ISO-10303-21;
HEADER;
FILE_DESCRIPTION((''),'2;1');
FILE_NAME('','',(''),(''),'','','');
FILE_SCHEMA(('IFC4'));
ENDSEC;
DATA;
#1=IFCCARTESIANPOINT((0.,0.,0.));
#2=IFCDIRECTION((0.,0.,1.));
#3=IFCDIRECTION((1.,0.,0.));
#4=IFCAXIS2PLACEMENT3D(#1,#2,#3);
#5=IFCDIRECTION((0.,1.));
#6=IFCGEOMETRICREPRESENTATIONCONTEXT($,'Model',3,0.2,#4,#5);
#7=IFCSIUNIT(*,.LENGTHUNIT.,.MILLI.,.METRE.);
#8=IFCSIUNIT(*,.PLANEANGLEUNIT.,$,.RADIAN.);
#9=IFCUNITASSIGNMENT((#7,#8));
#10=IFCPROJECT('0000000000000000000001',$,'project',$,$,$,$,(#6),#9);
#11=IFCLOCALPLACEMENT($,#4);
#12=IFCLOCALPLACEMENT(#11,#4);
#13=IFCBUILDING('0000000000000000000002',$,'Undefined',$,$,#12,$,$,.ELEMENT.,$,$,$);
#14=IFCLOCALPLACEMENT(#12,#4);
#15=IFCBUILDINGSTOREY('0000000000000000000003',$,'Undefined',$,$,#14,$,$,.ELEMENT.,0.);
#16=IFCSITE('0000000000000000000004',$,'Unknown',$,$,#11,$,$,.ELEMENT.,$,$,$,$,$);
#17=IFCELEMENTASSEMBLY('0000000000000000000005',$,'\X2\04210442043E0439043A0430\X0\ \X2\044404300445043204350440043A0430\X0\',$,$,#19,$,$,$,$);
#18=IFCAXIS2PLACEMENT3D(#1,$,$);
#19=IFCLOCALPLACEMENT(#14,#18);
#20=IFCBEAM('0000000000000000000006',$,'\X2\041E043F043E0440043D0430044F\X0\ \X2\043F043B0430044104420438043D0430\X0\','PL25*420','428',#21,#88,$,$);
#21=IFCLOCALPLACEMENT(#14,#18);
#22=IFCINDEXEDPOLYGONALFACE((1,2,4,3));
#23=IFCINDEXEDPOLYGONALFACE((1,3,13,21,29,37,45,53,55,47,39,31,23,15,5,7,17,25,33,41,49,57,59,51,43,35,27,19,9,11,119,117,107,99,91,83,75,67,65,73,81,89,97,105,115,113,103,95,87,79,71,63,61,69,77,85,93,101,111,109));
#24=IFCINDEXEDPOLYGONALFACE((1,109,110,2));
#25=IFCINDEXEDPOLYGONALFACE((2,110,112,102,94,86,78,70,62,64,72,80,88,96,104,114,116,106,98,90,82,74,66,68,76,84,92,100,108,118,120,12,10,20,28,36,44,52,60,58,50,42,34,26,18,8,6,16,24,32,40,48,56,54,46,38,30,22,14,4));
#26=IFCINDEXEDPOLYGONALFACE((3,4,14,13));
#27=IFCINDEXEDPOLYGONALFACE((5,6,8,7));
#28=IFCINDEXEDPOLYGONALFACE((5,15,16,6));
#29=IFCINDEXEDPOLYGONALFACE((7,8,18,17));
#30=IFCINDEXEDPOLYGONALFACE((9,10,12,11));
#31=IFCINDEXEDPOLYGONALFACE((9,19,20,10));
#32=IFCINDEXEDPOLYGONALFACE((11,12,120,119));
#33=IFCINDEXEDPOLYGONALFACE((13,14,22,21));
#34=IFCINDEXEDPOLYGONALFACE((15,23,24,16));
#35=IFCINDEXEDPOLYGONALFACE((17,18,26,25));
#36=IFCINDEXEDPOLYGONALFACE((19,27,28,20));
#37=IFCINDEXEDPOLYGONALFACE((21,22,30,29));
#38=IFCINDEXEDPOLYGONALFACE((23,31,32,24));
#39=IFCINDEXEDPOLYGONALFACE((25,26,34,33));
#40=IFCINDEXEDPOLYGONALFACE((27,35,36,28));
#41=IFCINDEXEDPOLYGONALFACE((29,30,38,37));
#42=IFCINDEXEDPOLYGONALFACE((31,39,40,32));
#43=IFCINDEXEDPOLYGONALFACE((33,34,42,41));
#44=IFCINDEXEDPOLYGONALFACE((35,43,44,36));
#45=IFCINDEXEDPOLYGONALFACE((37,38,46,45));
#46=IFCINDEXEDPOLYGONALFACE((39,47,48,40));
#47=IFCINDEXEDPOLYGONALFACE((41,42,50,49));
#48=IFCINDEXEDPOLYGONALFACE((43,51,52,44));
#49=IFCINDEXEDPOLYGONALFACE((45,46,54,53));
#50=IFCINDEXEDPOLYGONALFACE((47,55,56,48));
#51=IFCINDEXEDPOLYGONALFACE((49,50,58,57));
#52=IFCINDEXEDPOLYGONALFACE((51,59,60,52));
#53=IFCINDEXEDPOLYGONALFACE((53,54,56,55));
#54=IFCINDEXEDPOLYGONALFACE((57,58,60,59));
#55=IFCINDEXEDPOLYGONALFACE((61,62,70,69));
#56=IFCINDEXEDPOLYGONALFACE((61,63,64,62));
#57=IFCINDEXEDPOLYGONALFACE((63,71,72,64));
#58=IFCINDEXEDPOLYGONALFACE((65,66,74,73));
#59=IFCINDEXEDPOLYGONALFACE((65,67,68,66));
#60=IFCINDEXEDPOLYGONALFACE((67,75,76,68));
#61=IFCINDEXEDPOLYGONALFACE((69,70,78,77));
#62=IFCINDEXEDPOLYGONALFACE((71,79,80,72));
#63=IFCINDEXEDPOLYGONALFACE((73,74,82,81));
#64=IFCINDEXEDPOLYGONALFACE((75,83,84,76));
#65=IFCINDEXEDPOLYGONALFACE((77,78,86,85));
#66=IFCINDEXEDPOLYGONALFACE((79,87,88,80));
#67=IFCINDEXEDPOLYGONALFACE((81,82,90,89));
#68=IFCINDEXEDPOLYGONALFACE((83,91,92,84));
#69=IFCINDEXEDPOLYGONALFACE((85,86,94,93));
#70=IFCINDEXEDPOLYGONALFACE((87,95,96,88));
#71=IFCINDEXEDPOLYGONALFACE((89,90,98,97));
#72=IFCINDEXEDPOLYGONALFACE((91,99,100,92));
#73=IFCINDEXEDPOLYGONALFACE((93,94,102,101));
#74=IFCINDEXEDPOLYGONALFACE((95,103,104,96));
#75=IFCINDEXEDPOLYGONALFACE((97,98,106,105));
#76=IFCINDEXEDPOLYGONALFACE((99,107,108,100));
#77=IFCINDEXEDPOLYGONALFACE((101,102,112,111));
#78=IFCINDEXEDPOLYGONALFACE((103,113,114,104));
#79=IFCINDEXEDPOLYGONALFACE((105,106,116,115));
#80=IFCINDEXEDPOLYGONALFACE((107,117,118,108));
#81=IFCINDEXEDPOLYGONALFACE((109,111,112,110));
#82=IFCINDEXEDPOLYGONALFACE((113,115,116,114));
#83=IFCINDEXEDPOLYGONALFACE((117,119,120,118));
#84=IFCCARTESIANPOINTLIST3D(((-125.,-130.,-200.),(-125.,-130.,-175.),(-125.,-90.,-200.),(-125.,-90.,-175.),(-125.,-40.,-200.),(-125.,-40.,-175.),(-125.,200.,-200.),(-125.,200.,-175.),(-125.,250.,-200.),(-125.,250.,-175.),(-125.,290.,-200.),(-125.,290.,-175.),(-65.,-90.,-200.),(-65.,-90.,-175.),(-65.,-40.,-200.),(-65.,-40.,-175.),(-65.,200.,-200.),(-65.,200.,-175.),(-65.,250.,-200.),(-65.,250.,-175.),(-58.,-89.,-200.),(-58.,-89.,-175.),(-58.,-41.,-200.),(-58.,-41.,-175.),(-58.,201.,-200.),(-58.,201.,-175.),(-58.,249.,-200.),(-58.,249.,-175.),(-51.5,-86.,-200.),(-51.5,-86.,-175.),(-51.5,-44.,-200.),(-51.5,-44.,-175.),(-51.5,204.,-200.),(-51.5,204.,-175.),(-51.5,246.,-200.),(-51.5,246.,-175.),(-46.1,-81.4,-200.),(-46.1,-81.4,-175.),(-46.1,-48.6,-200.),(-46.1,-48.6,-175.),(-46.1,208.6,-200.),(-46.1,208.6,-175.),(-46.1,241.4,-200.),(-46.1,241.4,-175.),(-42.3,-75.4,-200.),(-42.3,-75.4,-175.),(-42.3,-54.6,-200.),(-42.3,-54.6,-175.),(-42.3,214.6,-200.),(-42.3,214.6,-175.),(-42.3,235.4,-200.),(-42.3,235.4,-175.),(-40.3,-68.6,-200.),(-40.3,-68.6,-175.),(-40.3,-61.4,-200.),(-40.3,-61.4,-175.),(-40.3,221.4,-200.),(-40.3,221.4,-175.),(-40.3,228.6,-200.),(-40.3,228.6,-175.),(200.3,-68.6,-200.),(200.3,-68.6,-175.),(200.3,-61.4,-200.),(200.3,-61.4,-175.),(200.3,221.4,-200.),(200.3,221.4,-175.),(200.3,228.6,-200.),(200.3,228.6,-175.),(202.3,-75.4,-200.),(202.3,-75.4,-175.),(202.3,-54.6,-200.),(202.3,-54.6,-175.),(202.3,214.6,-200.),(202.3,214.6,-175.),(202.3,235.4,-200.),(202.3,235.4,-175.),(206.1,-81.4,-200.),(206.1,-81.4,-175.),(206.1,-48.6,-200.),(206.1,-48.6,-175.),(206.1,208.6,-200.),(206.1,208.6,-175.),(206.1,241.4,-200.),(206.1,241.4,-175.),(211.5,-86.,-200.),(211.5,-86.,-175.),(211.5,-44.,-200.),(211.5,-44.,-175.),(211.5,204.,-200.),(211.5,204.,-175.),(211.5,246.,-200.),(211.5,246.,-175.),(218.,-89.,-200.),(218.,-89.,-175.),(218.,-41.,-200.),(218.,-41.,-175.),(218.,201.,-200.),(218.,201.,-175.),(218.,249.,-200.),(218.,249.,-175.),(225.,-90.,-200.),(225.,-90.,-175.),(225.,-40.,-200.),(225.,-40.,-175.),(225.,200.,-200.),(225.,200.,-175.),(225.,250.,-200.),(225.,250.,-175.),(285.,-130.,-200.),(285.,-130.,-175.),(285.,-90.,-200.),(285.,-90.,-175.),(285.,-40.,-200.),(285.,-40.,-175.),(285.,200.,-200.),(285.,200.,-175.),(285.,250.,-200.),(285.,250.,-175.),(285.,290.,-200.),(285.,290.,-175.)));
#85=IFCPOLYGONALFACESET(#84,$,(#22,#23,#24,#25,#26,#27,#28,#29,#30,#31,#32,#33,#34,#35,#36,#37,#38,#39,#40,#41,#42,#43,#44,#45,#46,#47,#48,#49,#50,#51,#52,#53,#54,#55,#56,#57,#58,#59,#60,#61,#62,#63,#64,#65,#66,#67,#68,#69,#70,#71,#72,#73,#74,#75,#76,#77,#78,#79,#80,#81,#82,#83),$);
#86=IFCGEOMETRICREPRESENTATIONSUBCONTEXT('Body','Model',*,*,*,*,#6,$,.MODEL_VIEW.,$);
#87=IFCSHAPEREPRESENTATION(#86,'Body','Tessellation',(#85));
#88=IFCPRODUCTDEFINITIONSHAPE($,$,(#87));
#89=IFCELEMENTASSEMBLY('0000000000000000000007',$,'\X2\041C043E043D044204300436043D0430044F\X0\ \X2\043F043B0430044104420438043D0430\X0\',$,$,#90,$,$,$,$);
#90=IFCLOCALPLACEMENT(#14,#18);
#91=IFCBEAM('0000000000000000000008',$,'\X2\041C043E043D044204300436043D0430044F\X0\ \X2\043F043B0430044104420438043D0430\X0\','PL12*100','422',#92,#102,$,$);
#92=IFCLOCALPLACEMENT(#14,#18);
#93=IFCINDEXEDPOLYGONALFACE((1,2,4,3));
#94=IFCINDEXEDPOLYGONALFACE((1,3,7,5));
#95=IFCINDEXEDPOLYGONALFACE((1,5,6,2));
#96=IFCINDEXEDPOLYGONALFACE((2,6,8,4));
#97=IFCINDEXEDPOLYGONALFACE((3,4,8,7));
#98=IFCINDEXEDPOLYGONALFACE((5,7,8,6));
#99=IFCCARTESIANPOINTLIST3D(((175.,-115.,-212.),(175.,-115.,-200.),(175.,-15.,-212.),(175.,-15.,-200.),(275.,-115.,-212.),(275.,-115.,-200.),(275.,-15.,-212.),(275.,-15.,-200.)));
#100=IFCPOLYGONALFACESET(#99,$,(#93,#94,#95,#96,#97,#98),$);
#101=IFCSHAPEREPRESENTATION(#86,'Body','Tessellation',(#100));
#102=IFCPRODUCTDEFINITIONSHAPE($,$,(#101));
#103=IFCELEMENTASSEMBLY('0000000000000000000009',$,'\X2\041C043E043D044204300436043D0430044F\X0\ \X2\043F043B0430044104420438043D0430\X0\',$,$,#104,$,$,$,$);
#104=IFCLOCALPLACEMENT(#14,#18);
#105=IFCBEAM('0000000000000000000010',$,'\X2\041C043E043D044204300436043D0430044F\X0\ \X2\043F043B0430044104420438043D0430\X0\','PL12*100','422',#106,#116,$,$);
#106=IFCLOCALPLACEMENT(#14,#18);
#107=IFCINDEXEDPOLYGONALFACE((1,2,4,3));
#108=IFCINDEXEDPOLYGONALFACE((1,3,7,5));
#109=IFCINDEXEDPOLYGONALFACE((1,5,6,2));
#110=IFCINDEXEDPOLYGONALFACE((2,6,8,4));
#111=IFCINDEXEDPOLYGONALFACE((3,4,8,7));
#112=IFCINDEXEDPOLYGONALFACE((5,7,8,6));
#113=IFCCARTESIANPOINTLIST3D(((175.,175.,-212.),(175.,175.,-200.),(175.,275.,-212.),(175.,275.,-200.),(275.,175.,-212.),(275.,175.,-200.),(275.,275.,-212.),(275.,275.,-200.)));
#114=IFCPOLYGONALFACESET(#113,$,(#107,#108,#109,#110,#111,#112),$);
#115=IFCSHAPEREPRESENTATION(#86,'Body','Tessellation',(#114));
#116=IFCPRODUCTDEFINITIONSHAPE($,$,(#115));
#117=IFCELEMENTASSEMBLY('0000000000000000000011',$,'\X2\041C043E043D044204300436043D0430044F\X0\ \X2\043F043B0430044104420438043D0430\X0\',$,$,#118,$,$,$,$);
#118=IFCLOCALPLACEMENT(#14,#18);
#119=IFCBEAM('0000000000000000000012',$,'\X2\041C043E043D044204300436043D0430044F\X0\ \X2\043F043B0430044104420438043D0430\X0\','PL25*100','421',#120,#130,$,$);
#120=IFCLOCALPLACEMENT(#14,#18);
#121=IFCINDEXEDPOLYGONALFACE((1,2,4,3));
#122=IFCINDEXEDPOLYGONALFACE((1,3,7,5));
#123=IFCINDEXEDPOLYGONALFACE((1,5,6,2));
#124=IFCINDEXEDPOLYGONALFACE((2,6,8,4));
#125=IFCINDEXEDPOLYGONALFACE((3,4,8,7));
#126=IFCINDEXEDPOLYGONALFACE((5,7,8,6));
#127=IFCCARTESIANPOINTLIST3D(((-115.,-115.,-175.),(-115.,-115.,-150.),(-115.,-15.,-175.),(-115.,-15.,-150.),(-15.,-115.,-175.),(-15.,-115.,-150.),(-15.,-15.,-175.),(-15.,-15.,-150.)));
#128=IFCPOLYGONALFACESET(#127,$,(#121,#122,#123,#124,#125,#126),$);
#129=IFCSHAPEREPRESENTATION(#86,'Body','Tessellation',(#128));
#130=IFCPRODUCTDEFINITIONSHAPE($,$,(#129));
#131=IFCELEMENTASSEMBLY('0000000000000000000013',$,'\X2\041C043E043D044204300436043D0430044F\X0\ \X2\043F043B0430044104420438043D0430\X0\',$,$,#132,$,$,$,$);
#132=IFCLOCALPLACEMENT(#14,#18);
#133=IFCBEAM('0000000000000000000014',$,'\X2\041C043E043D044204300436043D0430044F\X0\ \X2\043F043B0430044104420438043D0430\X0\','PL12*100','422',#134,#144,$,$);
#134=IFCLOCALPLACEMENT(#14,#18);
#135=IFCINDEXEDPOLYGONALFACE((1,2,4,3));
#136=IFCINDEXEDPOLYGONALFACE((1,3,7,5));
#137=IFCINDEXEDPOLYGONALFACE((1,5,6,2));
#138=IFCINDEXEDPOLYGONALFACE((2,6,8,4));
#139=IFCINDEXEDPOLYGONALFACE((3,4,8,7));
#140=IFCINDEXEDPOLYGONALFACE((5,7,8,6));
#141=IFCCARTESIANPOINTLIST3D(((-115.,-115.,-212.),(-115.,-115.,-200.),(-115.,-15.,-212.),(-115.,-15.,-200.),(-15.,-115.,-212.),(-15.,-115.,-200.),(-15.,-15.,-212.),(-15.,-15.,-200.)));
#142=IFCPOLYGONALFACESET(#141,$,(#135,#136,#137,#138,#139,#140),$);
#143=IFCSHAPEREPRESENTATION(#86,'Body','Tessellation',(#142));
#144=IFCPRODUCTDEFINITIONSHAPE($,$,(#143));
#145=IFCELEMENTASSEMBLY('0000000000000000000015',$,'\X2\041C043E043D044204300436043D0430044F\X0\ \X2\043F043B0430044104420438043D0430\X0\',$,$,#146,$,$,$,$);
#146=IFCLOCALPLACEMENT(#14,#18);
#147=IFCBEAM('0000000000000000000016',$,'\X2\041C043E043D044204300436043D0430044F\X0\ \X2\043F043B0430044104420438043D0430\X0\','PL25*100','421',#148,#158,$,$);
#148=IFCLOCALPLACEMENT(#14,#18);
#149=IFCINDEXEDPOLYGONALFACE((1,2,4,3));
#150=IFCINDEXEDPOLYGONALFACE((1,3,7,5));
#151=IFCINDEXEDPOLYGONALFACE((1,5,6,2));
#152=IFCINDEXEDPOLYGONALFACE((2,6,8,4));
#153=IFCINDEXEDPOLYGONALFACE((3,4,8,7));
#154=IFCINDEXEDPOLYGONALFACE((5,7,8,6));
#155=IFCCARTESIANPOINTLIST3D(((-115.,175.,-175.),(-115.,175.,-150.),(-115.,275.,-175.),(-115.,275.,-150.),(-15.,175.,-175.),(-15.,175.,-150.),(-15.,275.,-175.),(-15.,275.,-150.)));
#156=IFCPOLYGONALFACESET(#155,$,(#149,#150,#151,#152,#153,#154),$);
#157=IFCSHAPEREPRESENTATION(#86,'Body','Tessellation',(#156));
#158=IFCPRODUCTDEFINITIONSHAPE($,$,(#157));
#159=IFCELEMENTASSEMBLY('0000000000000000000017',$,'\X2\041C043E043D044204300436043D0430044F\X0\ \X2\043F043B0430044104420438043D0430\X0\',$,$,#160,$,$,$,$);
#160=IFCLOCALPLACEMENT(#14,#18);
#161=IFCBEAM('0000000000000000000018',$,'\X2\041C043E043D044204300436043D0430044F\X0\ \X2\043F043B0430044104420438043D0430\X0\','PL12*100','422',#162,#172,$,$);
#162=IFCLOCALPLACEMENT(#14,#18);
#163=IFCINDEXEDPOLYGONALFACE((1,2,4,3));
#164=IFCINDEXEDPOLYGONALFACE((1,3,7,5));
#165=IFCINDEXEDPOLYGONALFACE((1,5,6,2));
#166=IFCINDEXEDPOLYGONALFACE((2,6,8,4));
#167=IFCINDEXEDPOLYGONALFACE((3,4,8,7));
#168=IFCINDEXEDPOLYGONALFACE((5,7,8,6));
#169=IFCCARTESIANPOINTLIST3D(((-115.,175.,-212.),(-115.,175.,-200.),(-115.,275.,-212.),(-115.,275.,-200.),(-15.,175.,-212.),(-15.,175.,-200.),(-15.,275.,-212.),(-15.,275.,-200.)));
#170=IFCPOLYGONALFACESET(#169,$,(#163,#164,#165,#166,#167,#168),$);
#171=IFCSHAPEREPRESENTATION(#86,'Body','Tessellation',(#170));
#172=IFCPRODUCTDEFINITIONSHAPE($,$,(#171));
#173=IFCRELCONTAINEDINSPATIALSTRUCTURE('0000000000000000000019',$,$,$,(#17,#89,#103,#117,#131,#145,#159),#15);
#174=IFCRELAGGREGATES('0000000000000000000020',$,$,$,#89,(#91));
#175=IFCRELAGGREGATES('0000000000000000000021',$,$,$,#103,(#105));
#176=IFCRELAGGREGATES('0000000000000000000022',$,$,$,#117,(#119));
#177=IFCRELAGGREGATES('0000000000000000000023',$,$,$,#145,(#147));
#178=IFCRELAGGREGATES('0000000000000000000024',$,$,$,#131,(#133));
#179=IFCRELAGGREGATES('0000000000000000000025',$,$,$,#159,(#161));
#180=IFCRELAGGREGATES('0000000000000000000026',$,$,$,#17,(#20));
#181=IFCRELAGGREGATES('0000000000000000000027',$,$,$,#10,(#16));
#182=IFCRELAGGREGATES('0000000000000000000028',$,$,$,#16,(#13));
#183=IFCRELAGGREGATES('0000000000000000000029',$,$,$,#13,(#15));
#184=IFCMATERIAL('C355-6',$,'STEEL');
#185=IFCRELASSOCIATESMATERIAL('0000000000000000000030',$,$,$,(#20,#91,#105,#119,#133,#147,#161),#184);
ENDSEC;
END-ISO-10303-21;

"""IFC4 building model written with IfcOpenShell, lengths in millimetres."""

from ifc_helpers import new_model, si_unit, direction, frame, origin_with_axes, place, context, subcontext, project, spatial, line, arc, indexed_curve, outline, extrude, material, element, aggregate, save


model = new_model("IFC4")

# Units and contexts
model_context = context("Model", 3, precision=0.2, world=origin_with_axes(), true_north=direction((0.0, 1.0)))
body_context = subcontext(model_context, "Body", "Model", "MODEL_VIEW")
ifc_project = project(units=[si_unit("LENGTHUNIT", "METRE", prefix="MILLI"), si_unit("PLANEANGLEUNIT", "RADIAN")], contexts=[model_context])

# Site, building, storey
site_placement = place(None, origin_with_axes())
site = spatial("IfcSite", under=ifc_project, at=site_placement, Name="Unknown", CompositionType="ELEMENT")
building_placement = place(site_placement, origin_with_axes())
building = spatial("IfcBuilding", under=site, at=building_placement, Name="Undefined", CompositionType="ELEMENT")
storey_placement = place(building_placement, origin_with_axes())
storey = spatial("IfcBuildingStorey", under=building, at=storey_placement, Name="Undefined", CompositionType="ELEMENT", Elevation=0.0)

# Element assembly, beam, voiding features
assembly_1_placement = place(storey_placement, frame((80.0, 80.0, -200.0), z_axis=(0.0, -1.0, 0.0), x_axis=(0.0, 0.0, 1.0)))
assembly_1 = element("IfcElementAssembly", 1, at=assembly_1_placement, inside=storey, Name="Стойка фахверка")
ifc_material_1 = material(Name="C355-6", Category="STEEL")
beam_1_placement = place(assembly_1_placement, frame((12.5, 205.0, 0.0), z_axis=(-1.0, 0.0, 0.0), x_axis=(0.0, -1.0, 0.0)))
beam_1 = element("IfcBeam", 2, at=beam_1_placement, material=ifc_material_1, Name="Опорная пластина", Description="PL25*420", ObjectType="428", context=body_context, shape_type="SolidModel", body=[
    extrude(outline(indexed_curve([(-12.5, -210.0), (12.5, -210.0), (12.5, 210.0), (-12.5, 210.0)], segments=[line(1, 2, 3, 4, 1)])), frame((0.0, 0.0, 0.0), z_axis=(-1.0, 0.0, 0.0), x_axis=(0.0, 0.0, 1.0)), (0.0, 0.0, -1.0), 410.0),
])
voiding_feature_1_placement = place(beam_1_placement, frame((410.0, 170.0, 0.0), z_axis=(0.0, 0.0, -1.0), x_axis=(0.0, -1.0, 0.0)))
element("IfcVoidingFeature", 3, at=voiding_feature_1_placement, cuts=beam_1, Name="Пластина", ObjectType="(?)", PredefinedType="HOLE", context=body_context, shape_type="SolidModel", body=[
    extrude(outline(indexed_curve([(0.0, 0.0), (50.0, 0.0), (50.0, 60.0), (42.7, 77.7), (25.0, 85.0), (25.0, 85.0), (7.3, 77.7), (0.0, 60.0)], segments=[line(1, 2, 3), arc(3, 4, 5), line(5, 6), arc(6, 7, 8), line(8, 1)])), frame((0.0, 0.0, 12.5), z_axis=(0.0, 0.0, 1.0), x_axis=(1.0, 0.0, 0.0)), (0.0, 0.0, -1.0), 25.0),
])
voiding_feature_2_placement = place(beam_1_placement, frame((410.0, -120.0, 0.0), z_axis=(0.0, 0.0, -1.0), x_axis=(0.0, -1.0, 0.0)))
element("IfcVoidingFeature", 4, at=voiding_feature_2_placement, cuts=beam_1, Name="Пластина", ObjectType="(?)", PredefinedType="HOLE", context=body_context, shape_type="SolidModel", body=[
    extrude(outline(indexed_curve([(0.0, 0.0), (50.0, 0.0), (50.0, 60.0), (42.7, 77.7), (25.0, 85.0), (25.0, 85.0), (7.3, 77.7), (0.0, 60.0)], segments=[line(1, 2, 3), arc(3, 4, 5), line(5, 6), arc(6, 7, 8), line(8, 1)])), frame((0.0, 0.0, 12.5), z_axis=(0.0, 0.0, 1.0), x_axis=(1.0, 0.0, 0.0)), (0.0, 0.0, -1.0), 25.0),
])
voiding_feature_3_placement = place(beam_1_placement, frame((0.0, 120.0, 0.0), z_axis=(0.0, 0.0, -1.0), x_axis=(0.0, 1.0, 0.0)))
element("IfcVoidingFeature", 5, at=voiding_feature_3_placement, cuts=beam_1, Name="Пластина", ObjectType="(?)", PredefinedType="HOLE", context=body_context, shape_type="SolidModel", body=[
    extrude(outline(indexed_curve([(0.0, 0.0), (50.0, 0.0), (50.0, 60.0), (42.7, 77.7), (25.0, 85.0), (25.0, 85.0), (7.3, 77.7), (0.0, 60.0)], segments=[line(1, 2, 3), arc(3, 4, 5), line(5, 6), arc(6, 7, 8), line(8, 1)])), frame((0.0, 0.0, 12.5), z_axis=(0.0, 0.0, 1.0), x_axis=(1.0, 0.0, 0.0)), (0.0, 0.0, -1.0), 25.0),
])
voiding_feature_4_placement = place(beam_1_placement, frame((0.0, -170.0, 0.0), z_axis=(0.0, 0.0, -1.0), x_axis=(0.0, 1.0, 0.0)))
element("IfcVoidingFeature", 6, at=voiding_feature_4_placement, cuts=beam_1, Name="Пластина", ObjectType="(?)", PredefinedType="HOLE", context=body_context, shape_type="SolidModel", body=[
    extrude(outline(indexed_curve([(0.0, 0.0), (50.0, 0.0), (50.0, 60.0), (42.7, 77.7), (25.0, 85.0), (25.0, 85.0), (7.3, 77.7), (0.0, 60.0)], segments=[line(1, 2, 3), arc(3, 4, 5), line(5, 6), arc(6, 7, 8), line(8, 1)])), frame((0.0, 0.0, 12.5), z_axis=(0.0, 0.0, 1.0), x_axis=(1.0, 0.0, 0.0)), (0.0, 0.0, -1.0), 25.0),
])

# Element assemblies, beams
assembly_2_placement = place(storey_placement, frame((175.0, -65.0, -206.0), z_axis=(0.0, 0.0, -1.0), x_axis=(1.0, 0.0, 0.0)))
assembly_2 = element("IfcElementAssembly", 7, at=assembly_2_placement, inside=storey, Name="Монтажная пластина")
beam_2_placement = place(assembly_2_placement, origin_with_axes())
beam_2 = element("IfcBeam", 8, at=beam_2_placement, material=ifc_material_1, Name="Монтажная пластина", Description="PL12*100", ObjectType="422", context=body_context, shape_type="SolidModel", body=[
    extrude(outline(indexed_curve([(-6.0, -50.0), (6.0, -50.0), (6.0, 50.0), (-6.0, 50.0)], segments=[line(1, 2, 3, 4, 1)])), frame((0.0, 0.0, 0.0), z_axis=(-1.0, 0.0, 0.0), x_axis=(0.0, 0.0, 1.0)), (0.0, 0.0, -1.0), 100.0),
])
aggregate(assembly_2, [beam_2])
assembly_3_placement = place(storey_placement, frame((175.0, 225.0, -206.0), z_axis=(0.0, 0.0, -1.0), x_axis=(1.0, 0.0, 0.0)))
assembly_3 = element("IfcElementAssembly", 9, at=assembly_3_placement, inside=storey, Name="Монтажная пластина")
beam_3_placement = place(assembly_3_placement, origin_with_axes())
beam_3 = element("IfcBeam", 10, at=beam_3_placement, material=ifc_material_1, Name="Монтажная пластина", Description="PL12*100", ObjectType="422", context=body_context, shape_type="SolidModel", body=[
    extrude(outline(indexed_curve([(-6.0, -50.0), (6.0, -50.0), (6.0, 50.0), (-6.0, 50.0)], segments=[line(1, 2, 3, 4, 1)])), frame((0.0, 0.0, 0.0), z_axis=(-1.0, 0.0, 0.0), x_axis=(0.0, 0.0, 1.0)), (0.0, 0.0, -1.0), 100.0),
])
aggregate(assembly_3, [beam_3])
assembly_4_placement = place(storey_placement, frame((-115.0, -65.0, -162.5), z_axis=(0.0, 0.0, -1.0), x_axis=(1.0, 0.0, 0.0)))
assembly_4 = element("IfcElementAssembly", 11, at=assembly_4_placement, inside=storey, Name="Монтажная пластина")
beam_4_placement = place(assembly_4_placement, origin_with_axes())
beam_4 = element("IfcBeam", 12, at=beam_4_placement, material=ifc_material_1, Name="Монтажная пластина", Description="PL25*100", ObjectType="421", context=body_context, shape_type="SolidModel", body=[
    extrude(outline(indexed_curve([(-12.5, -50.0), (12.5, -50.0), (12.5, 50.0), (-12.5, 50.0)], segments=[line(1, 2, 3, 4, 1)])), frame((0.0, 0.0, 0.0), z_axis=(-1.0, 0.0, 0.0), x_axis=(0.0, 0.0, 1.0)), (0.0, 0.0, -1.0), 100.0),
])
assembly_5_placement = place(storey_placement, frame((-115.0, -65.0, -206.0), z_axis=(0.0, 0.0, -1.0), x_axis=(1.0, 0.0, 0.0)))
assembly_5 = element("IfcElementAssembly", 13, at=assembly_5_placement, inside=storey, Name="Монтажная пластина")
beam_5_placement = place(assembly_5_placement, origin_with_axes())
beam_5 = element("IfcBeam", 14, at=beam_5_placement, material=ifc_material_1, Name="Монтажная пластина", Description="PL12*100", ObjectType="422", context=body_context, shape_type="SolidModel", body=[
    extrude(outline(indexed_curve([(-6.0, -50.0), (6.0, -50.0), (6.0, 50.0), (-6.0, 50.0)], segments=[line(1, 2, 3, 4, 1)])), frame((0.0, 0.0, 0.0), z_axis=(-1.0, 0.0, 0.0), x_axis=(0.0, 0.0, 1.0)), (0.0, 0.0, -1.0), 100.0),
])
assembly_6_placement = place(storey_placement, frame((-115.0, 225.0, -162.5), z_axis=(0.0, 0.0, -1.0), x_axis=(1.0, 0.0, 0.0)))
assembly_6 = element("IfcElementAssembly", 15, at=assembly_6_placement, inside=storey, Name="Монтажная пластина")
beam_6_placement = place(assembly_6_placement, origin_with_axes())
beam_6 = element("IfcBeam", 16, at=beam_6_placement, material=ifc_material_1, Name="Монтажная пластина", Description="PL25*100", ObjectType="421", context=body_context, shape_type="SolidModel", body=[
    extrude(outline(indexed_curve([(-12.5, -50.0), (12.5, -50.0), (12.5, 50.0), (-12.5, 50.0)], segments=[line(1, 2, 3, 4, 1)])), frame((0.0, 0.0, 0.0), z_axis=(-1.0, 0.0, 0.0), x_axis=(0.0, 0.0, 1.0)), (0.0, 0.0, -1.0), 100.0),
])
assembly_7_placement = place(storey_placement, frame((-115.0, 225.0, -206.0), z_axis=(0.0, 0.0, -1.0), x_axis=(1.0, 0.0, 0.0)))
assembly_7 = element("IfcElementAssembly", 17, at=assembly_7_placement, inside=storey, Name="Монтажная пластина")
beam_7_placement = place(assembly_7_placement, origin_with_axes())
beam_7 = element("IfcBeam", 18, at=beam_7_placement, material=ifc_material_1, Name="Монтажная пластина", Description="PL12*100", ObjectType="422", context=body_context, shape_type="SolidModel", body=[
    extrude(outline(indexed_curve([(-6.0, -50.0), (6.0, -50.0), (6.0, 50.0), (-6.0, 50.0)], segments=[line(1, 2, 3, 4, 1)])), frame((0.0, 0.0, 0.0), z_axis=(-1.0, 0.0, 0.0), x_axis=(0.0, 0.0, 1.0)), (0.0, 0.0, -1.0), 100.0),
])

aggregate(assembly_4, [beam_4])
aggregate(assembly_6, [beam_6])
aggregate(assembly_5, [beam_5])
aggregate(assembly_7, [beam_7])
aggregate(assembly_1, [beam_1])

save(model, "model.ifc")
